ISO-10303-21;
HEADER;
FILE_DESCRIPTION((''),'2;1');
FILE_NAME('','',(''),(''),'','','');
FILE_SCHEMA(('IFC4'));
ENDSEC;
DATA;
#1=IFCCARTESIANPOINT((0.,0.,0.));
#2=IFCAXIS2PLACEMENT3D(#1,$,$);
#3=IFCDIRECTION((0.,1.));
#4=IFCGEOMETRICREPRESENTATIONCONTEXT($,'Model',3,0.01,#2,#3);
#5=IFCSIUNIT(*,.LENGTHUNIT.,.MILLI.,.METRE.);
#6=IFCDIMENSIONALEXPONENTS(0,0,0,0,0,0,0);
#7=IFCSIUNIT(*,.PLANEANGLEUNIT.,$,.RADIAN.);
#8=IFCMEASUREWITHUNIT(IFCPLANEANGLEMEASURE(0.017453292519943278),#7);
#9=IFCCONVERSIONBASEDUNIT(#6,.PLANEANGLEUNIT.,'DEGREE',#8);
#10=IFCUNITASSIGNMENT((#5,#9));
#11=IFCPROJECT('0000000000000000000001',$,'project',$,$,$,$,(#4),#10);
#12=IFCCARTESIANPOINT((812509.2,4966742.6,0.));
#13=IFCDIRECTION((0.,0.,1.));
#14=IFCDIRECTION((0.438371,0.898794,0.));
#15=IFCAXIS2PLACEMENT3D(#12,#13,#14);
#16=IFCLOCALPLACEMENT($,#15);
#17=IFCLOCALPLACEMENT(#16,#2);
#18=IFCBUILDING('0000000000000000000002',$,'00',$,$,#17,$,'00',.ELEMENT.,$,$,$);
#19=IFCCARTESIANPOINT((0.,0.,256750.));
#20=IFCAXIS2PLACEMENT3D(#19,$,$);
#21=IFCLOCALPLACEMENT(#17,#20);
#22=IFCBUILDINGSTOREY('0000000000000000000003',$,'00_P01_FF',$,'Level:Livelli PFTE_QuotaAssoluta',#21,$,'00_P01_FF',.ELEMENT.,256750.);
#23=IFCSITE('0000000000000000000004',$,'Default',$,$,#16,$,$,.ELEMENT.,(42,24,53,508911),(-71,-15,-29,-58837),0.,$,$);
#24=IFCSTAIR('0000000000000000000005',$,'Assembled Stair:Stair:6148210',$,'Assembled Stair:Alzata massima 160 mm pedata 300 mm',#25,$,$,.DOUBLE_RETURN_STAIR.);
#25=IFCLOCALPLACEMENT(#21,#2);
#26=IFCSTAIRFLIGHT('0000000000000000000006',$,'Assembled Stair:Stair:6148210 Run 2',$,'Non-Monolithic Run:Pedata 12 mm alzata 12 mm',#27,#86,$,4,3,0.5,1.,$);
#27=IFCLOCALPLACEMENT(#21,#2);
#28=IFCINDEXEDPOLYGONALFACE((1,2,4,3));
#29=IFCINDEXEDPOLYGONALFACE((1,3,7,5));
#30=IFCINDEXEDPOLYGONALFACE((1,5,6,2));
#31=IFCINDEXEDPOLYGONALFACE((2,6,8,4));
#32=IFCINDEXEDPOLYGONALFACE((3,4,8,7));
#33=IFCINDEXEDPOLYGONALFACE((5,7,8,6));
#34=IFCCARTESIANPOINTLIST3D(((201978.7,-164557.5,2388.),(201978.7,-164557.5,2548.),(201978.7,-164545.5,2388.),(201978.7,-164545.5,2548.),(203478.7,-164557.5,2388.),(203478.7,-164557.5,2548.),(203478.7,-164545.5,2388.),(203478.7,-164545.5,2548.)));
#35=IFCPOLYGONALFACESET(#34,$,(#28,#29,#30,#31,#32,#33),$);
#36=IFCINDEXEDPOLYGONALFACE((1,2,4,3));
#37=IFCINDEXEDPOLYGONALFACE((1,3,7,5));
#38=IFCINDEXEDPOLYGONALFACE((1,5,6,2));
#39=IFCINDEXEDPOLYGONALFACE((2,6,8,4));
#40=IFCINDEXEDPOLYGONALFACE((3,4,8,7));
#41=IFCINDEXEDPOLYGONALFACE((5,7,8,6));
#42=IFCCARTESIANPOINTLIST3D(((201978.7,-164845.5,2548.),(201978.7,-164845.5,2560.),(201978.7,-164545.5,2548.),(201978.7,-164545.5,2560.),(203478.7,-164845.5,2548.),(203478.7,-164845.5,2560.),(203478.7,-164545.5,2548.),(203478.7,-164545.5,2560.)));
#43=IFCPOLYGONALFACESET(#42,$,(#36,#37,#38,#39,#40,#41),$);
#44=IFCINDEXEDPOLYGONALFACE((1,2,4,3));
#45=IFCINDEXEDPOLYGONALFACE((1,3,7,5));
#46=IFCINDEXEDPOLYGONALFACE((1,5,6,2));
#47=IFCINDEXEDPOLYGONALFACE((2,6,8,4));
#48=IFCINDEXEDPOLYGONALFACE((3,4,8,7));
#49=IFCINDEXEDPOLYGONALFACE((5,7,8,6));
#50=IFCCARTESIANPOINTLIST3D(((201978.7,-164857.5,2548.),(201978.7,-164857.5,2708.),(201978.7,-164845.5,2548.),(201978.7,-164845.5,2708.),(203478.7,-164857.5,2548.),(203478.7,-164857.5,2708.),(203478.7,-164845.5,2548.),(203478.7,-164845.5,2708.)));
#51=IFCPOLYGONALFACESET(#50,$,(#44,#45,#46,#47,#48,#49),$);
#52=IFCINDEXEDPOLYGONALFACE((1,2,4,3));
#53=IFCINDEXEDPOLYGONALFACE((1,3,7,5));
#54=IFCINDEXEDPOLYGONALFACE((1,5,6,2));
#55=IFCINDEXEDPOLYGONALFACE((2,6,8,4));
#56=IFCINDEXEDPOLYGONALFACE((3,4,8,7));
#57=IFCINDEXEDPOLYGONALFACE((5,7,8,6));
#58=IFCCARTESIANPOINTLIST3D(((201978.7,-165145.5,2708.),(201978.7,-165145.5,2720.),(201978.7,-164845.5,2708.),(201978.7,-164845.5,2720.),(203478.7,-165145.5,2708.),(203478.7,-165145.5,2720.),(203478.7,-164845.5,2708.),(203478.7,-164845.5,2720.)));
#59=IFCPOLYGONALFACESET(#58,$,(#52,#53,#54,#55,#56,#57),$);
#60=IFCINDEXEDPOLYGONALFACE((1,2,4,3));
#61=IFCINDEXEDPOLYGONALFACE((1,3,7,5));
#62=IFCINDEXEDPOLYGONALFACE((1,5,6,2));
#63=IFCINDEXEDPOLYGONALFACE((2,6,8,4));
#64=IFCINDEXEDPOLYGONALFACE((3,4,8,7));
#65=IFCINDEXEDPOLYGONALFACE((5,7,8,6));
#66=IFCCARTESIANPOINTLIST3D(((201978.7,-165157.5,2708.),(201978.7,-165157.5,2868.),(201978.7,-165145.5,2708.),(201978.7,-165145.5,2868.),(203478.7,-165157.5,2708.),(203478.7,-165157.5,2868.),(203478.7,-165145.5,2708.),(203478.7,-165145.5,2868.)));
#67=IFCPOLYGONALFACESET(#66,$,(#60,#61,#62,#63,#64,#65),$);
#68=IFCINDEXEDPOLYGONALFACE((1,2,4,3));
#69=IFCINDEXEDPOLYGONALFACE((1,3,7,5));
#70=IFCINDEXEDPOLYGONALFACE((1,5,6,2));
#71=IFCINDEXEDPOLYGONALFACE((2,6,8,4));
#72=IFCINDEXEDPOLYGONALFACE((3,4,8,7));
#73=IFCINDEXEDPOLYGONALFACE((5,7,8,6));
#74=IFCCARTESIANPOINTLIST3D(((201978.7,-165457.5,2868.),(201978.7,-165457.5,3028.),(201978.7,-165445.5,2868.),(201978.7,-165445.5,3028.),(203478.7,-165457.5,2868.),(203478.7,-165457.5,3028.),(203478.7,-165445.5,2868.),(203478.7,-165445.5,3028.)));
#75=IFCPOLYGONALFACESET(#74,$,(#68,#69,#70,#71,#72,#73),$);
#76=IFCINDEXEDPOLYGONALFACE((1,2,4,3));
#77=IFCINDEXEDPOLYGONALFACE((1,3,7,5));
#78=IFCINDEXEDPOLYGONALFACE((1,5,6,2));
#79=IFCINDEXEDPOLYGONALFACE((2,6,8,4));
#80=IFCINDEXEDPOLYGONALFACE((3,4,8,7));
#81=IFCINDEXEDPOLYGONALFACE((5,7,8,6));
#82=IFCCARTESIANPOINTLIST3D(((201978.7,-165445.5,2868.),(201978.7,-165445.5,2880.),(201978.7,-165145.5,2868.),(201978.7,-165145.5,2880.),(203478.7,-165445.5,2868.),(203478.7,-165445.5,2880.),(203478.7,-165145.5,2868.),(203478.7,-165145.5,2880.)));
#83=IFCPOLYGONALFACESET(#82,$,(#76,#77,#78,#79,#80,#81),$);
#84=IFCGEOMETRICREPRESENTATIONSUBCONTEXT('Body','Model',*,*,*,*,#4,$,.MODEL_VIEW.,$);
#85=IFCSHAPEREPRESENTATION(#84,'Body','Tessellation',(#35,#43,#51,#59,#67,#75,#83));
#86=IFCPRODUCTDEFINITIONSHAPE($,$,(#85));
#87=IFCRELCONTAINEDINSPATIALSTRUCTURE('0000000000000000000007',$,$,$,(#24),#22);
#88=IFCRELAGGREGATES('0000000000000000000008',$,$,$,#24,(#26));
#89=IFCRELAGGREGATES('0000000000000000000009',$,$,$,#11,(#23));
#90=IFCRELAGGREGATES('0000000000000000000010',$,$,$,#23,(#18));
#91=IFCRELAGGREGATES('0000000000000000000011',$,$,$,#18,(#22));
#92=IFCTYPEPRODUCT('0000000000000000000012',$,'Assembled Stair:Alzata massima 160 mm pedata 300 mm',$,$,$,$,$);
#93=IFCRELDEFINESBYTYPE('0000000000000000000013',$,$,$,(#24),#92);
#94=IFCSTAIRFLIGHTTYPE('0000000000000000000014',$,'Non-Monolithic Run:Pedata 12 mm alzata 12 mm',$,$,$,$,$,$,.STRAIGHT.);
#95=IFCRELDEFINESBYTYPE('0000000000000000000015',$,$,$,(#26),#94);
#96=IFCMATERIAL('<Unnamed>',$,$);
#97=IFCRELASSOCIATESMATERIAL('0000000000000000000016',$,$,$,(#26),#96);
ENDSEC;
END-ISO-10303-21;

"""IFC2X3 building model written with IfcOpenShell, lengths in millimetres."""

from ifc_helpers import new_model, entity, si_unit, converted_unit, direction, frame, origin, origin_2d_with_axis, place, context, subcontext, project, spatial, rectangle, extrude, material, type_object, element, aggregate, save


model = new_model("IFC2X3")

# Units and contexts
model_context = context("Model", 3, precision=0.01, world=origin(), true_north=direction((0.0, 1.0)))
body_context = subcontext(model_context, "Body", "Model", "MODEL_VIEW")
ifc_project = project(units=[si_unit("LENGTHUNIT", "METRE", prefix="MILLI"), converted_unit("PLANEANGLEUNIT", "DEGREE", entity("IfcPlaneAngleMeasure", 0.017453292519943278), si_unit("PLANEANGLEUNIT", "RADIAN"), dimensions=[0, 0, 0, 0, 0, 0, 0])], contexts=[model_context])

# Site, building, storey
site_placement = place(None, frame((812509.2, 4966742.6, 0.0), z_axis=(0.0, 0.0, 1.0), x_axis=(0.438371, 0.898794, 0.0)))
site = spatial("IfcSite", under=ifc_project, at=site_placement, Name="Default", CompositionType="ELEMENT", RefLatitude=(42, 24, 53, 508911), RefLongitude=(-71, -15, -29, -58837), RefElevation=0.0)
building_placement = place(site_placement, origin())
building = spatial("IfcBuilding", under=site, at=building_placement, Name="00", LongName="00", CompositionType="ELEMENT")
storey_placement = place(building_placement, frame((0.0, 0.0, 256750.0)))
storey = spatial("IfcBuildingStorey", under=building, at=storey_placement, Name="00_P01_FF", ObjectType="Level:Livelli PFTE_QuotaAssoluta", LongName="00_P01_FF", CompositionType="ELEMENT", Elevation=256750.0)

# Stair
type_product = type_object("IfcTypeProduct", Name="Assembled Stair:Alzata massima 160 mm pedata 300 mm")
ifc_material = material(Name="<Unnamed>")
stair_1_placement = place(storey_placement, origin())
stair_1 = element("IfcStair", 1, at=stair_1_placement, inside=storey, type_object=type_product, Name="Assembled Stair:Stair:6148210", ObjectType="Assembled Stair:Alzata massima 160 mm pedata 300 mm", ShapeType="DOUBLE_RETURN_STAIR")

# Stair flight
stair_flight_type = type_object("IfcStairFlightType", Name="Non-Monolithic Run:Pedata 12 mm alzata 12 mm", PredefinedType="STRAIGHT")
stair_flight_1_placement = place(stair_1_placement, origin())
stair_flight_1 = element("IfcStairFlight", 2, at=stair_flight_1_placement, type_object=stair_flight_type, material=ifc_material, Name="Assembled Stair:Stair:6148210 Run 2", ObjectType="Non-Monolithic Run:Pedata 12 mm alzata 12 mm", NumberOfRiser=4, NumberOfTreads=3, RiserHeight=0.5, TreadLength=1.0, context=body_context, shape_type="SweptSolid", body=[
    extrude(rectangle(XDim=1500.0, YDim=12.0, at=origin_2d_with_axis()), frame((202728.7, -164551.5, 2388.0)), (0.0, 0.0, 1.0), 160.0),
    extrude(rectangle(XDim=300.0, YDim=1500.0, at=origin_2d_with_axis()), frame((202728.7, -164695.5, 2548.0), z_axis=(0.0, 0.0, 1.0), x_axis=(0.0, 1.0, 0.0)), (0.0, 0.0, 1.0), 12.0),
    extrude(rectangle(XDim=1500.0, YDim=12.0, at=origin_2d_with_axis()), frame((202728.7, -164851.5, 2548.0)), (0.0, 0.0, 1.0), 160.0),
    extrude(rectangle(XDim=300.0, YDim=1500.0, at=origin_2d_with_axis()), frame((202728.7, -164995.5, 2708.0), z_axis=(0.0, 0.0, 1.0), x_axis=(0.0, 1.0, 0.0)), (0.0, 0.0, 1.0), 12.0),
    extrude(rectangle(XDim=1500.0, YDim=12.0, at=origin_2d_with_axis()), frame((202728.7, -165151.5, 2708.0)), (0.0, 0.0, 1.0), 160.0),
    extrude(rectangle(XDim=1500.0, YDim=12.0, at=origin_2d_with_axis()), frame((202728.7, -165451.5, 2868.0)), (0.0, 0.0, 1.0), 160.0),
    extrude(rectangle(XDim=300.0, YDim=1500.0, at=origin_2d_with_axis()), frame((202728.7, -165295.5, 2868.0), z_axis=(0.0, 0.0, 1.0), x_axis=(0.0, 1.0, 0.0)), (0.0, 0.0, 1.0), 12.0),
])
aggregate(stair_1, [stair_flight_1])

save(model, "model.ifc")
